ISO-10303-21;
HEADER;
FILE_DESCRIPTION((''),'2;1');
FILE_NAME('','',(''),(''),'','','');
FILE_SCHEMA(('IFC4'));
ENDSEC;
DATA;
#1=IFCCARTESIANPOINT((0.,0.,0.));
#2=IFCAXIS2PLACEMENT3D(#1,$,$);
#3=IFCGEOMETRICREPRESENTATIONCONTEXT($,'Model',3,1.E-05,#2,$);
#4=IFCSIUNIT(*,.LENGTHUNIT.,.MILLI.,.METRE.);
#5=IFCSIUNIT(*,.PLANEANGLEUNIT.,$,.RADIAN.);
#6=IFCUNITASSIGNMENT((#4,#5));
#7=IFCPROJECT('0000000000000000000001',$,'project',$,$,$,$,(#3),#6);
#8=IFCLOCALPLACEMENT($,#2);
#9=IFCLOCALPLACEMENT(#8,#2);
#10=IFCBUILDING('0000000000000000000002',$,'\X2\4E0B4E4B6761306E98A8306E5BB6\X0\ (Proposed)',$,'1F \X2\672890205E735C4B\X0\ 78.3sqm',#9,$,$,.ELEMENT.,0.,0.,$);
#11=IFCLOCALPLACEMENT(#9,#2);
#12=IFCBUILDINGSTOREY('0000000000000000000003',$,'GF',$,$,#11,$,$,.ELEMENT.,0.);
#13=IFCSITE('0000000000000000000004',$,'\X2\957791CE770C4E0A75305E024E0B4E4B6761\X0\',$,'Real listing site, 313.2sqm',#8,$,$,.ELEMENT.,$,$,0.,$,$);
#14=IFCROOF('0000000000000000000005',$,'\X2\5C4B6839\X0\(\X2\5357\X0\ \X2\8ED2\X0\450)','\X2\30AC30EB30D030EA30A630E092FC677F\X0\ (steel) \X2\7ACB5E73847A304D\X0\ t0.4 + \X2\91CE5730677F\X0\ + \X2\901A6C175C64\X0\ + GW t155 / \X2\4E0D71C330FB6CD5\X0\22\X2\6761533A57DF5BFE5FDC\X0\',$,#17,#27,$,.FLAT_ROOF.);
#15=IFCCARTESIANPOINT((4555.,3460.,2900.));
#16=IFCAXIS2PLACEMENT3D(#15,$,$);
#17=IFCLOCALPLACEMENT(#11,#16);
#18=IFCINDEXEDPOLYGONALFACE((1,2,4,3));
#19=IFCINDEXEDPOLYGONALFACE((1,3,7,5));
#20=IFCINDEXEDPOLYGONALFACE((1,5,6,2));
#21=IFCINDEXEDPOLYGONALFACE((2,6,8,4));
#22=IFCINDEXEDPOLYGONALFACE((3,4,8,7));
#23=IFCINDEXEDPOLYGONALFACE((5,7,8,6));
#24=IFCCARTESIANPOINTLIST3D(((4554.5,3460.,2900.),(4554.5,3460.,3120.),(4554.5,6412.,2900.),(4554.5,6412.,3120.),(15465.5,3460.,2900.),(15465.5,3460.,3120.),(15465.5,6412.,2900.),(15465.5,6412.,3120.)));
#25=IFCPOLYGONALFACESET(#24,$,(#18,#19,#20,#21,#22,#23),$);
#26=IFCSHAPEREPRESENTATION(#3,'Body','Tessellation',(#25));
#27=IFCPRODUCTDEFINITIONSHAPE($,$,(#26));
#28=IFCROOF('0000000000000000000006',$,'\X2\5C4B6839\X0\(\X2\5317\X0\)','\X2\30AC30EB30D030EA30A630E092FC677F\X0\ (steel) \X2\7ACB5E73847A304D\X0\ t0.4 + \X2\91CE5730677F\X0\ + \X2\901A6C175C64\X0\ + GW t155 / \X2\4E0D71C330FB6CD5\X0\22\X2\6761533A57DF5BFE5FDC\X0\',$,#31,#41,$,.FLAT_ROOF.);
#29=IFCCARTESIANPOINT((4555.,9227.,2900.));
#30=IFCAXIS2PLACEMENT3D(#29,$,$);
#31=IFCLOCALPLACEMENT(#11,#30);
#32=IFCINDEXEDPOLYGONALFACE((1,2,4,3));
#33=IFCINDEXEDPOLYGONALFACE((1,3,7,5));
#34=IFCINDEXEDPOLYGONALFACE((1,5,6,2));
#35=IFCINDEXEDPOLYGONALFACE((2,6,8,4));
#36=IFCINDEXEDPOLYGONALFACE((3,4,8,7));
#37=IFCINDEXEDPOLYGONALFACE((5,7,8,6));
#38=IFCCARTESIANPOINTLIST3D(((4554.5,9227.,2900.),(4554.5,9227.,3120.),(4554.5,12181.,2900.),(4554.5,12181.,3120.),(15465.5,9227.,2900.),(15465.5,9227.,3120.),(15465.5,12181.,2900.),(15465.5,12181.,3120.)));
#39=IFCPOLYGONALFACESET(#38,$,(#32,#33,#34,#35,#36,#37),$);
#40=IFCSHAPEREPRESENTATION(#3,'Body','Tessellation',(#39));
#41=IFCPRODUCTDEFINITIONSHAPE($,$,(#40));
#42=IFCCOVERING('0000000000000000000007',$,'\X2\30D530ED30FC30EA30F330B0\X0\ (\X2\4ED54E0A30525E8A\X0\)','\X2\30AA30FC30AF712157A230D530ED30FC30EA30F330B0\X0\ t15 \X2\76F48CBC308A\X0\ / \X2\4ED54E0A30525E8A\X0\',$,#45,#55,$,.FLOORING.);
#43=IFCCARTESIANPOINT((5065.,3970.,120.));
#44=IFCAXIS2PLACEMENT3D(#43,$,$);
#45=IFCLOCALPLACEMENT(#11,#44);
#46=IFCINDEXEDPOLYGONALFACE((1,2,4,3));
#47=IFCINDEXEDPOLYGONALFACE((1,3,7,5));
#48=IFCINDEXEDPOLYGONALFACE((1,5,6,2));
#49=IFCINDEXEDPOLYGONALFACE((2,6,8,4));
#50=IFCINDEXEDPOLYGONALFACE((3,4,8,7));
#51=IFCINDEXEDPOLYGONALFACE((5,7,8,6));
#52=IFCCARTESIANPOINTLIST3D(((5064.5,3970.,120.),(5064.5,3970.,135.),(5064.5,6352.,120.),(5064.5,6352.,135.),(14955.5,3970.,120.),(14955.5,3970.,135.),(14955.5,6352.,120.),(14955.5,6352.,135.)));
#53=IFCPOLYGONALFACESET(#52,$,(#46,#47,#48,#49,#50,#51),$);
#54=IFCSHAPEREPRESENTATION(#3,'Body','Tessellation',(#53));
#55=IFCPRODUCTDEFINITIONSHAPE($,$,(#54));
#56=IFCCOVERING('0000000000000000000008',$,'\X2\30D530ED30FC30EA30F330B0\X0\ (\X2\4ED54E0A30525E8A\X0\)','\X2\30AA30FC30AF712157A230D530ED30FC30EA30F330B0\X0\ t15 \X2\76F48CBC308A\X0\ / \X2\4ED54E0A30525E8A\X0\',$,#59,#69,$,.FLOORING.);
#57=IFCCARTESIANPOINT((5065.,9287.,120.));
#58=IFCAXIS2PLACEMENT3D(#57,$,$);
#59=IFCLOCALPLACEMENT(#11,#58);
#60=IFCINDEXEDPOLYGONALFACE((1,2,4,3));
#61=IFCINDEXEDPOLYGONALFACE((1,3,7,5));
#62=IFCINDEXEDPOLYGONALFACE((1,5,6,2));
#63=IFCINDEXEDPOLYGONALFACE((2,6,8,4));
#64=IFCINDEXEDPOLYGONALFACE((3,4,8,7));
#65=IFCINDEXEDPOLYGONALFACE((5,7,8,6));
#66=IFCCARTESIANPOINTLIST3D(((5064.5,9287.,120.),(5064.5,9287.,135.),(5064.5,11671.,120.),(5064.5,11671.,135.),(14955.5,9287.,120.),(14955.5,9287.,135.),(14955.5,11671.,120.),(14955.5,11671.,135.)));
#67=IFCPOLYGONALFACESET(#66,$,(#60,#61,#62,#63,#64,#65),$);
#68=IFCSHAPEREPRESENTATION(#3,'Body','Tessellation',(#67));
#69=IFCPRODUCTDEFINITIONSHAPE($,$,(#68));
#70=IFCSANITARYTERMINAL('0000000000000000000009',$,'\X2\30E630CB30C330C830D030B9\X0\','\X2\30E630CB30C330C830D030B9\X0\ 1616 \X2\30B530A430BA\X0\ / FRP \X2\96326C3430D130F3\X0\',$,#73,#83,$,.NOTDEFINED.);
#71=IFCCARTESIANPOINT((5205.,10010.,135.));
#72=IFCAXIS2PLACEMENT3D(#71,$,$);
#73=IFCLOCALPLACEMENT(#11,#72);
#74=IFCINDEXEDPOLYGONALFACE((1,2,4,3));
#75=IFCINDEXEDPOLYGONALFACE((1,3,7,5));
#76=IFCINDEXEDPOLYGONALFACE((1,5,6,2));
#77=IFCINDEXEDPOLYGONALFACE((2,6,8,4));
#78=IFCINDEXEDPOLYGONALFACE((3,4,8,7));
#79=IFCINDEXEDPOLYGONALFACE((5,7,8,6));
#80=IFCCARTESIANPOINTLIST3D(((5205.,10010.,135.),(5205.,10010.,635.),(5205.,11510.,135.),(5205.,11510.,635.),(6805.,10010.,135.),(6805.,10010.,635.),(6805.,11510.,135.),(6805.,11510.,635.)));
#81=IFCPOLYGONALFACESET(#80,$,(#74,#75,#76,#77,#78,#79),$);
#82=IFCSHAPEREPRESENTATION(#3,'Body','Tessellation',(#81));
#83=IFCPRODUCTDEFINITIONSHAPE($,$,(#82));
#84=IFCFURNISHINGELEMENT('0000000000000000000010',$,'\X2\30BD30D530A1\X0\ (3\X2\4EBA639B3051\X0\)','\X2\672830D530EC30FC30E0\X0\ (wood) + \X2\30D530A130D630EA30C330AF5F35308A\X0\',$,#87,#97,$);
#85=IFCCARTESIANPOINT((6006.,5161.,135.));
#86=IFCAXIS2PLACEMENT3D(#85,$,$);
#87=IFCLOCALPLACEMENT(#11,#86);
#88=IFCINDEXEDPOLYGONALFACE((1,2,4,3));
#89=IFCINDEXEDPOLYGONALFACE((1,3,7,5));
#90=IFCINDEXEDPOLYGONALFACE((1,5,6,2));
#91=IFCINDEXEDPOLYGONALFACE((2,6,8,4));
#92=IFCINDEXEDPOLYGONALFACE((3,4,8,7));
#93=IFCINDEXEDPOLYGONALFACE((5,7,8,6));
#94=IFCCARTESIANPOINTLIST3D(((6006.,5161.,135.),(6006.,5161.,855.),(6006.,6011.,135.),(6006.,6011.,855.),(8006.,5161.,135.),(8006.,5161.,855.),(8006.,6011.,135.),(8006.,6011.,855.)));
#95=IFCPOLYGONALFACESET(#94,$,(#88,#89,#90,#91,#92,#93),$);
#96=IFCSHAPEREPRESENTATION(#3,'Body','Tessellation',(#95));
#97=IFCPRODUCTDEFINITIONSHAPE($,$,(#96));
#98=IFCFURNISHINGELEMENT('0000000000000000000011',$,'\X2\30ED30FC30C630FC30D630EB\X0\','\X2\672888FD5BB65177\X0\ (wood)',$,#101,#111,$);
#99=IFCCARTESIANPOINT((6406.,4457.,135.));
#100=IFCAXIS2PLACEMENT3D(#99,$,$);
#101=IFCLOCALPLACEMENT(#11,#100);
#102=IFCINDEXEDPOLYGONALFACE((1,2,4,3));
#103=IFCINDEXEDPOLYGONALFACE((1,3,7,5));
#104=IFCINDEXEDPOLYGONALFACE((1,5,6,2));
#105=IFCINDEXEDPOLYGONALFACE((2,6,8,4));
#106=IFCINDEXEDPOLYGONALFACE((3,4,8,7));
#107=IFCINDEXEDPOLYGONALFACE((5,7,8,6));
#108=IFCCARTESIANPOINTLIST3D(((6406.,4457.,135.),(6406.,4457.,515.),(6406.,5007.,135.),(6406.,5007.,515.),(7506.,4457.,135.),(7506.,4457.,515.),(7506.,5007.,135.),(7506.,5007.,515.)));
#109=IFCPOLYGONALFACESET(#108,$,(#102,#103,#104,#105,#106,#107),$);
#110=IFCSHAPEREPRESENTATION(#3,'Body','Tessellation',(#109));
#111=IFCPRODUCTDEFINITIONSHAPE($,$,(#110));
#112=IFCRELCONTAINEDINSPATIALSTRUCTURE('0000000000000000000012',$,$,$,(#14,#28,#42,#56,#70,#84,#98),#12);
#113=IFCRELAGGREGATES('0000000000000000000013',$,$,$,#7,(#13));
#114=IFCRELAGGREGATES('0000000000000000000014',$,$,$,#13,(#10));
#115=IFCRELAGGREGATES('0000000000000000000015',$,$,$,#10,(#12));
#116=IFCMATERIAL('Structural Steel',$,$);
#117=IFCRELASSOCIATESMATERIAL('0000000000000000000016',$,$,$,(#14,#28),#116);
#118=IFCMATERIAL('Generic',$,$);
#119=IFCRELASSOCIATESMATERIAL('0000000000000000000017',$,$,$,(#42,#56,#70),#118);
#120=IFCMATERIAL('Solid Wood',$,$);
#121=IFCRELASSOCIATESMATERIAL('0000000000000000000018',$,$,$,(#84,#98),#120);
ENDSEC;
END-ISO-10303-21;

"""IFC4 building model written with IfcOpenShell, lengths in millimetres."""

from ifc_helpers import new_model, si_unit, frame, frame_2d, origin, place, context, project, spatial, rectangle, extrude, material, element, save


model = new_model("IFC4")

# Units and contexts
model_context = context("Model", 3, precision=1e-05, world=origin())
ifc_project = project(units=[si_unit("LENGTHUNIT", "METRE", prefix="MILLI"), si_unit("PLANEANGLEUNIT", "RADIAN")], contexts=[model_context])

# Site, building, storey
site_placement = place(None, origin())
site = spatial("IfcSite", under=ifc_project, at=site_placement, Name="長野県上田市下之条", ObjectType="Real listing site, 313.2sqm", CompositionType="ELEMENT", RefElevation=0.0)
building_placement = place(site_placement, origin())
building = spatial("IfcBuilding", under=site, at=building_placement, Name="下之条の風の家 (Proposed)", ObjectType="1F 木造平屋 78.3sqm", CompositionType="ELEMENT", ElevationOfRefHeight=0.0, ElevationOfTerrain=0.0)
storey_placement = place(building_placement, origin())
storey = spatial("IfcBuildingStorey", under=building, at=storey_placement, Name="GF", CompositionType="ELEMENT", Elevation=0.0)

# Shared definitions
ifc_material_1 = material(Name="Solid Wood")

# Roofs
ifc_material_2 = material(Name="Structural Steel")
roof_1_placement = place(storey_placement, frame((4555.0, 3460.0, 2900.0)))
element("IfcRoof", 1, at=roof_1_placement, inside=storey, material=ifc_material_2, Name="屋根(南 軒450)", Description="ガルバリウム鋼板 (steel) 立平葺き t0.4 + 野地板 + 通気層 + GW t155 / 不燃・法22条区域対応", PredefinedType="FLAT_ROOF", context=model_context, shape_type="SweptSolid", body=[
    extrude(rectangle(XDim=10911.0, YDim=2952.0, at=frame_2d((5455.0, 1476.0))), frame((4555.0, 3460.0, 2900.0)), (0.0, 0.0, 1.0), 220.0),
])
roof_2_placement = place(storey_placement, frame((4555.0, 9227.0, 2900.0)))
element("IfcRoof", 2, at=roof_2_placement, inside=storey, material=ifc_material_2, Name="屋根(北)", Description="ガルバリウム鋼板 (steel) 立平葺き t0.4 + 野地板 + 通気層 + GW t155 / 不燃・法22条区域対応", PredefinedType="FLAT_ROOF", context=model_context, shape_type="SweptSolid", body=[
    extrude(rectangle(XDim=10911.0, YDim=2954.0, at=frame_2d((5455.0, 1477.0))), frame((4555.0, 9227.0, 2900.0)), (0.0, 0.0, 1.0), 220.0),
])

# Coverings
ifc_material_3 = material(Name="Generic")
covering_1_placement = place(storey_placement, frame((5065.0, 3970.0, 120.0)))
element("IfcCovering", 3, at=covering_1_placement, inside=storey, material=ifc_material_3, Name="フローリング (仕上げ床)", Description="オーク無垢フローリング t15 直貼り / 仕上げ床", PredefinedType="FLOORING", context=model_context, shape_type="SweptSolid", body=[
    extrude(rectangle(XDim=9891.0, YDim=2382.0, at=frame_2d((4945.0, 1191.0))), frame((5065.0, 3970.0, 120.0)), (0.0, 0.0, 1.0), 15.0),
])
covering_2_placement = place(storey_placement, frame((5065.0, 9287.0, 120.0)))
element("IfcCovering", 4, at=covering_2_placement, inside=storey, material=ifc_material_3, Name="フローリング (仕上げ床)", Description="オーク無垢フローリング t15 直貼り / 仕上げ床", PredefinedType="FLOORING", context=model_context, shape_type="SweptSolid", body=[
    extrude(rectangle(XDim=9891.0, YDim=2384.0, at=frame_2d((4945.0, 1192.0))), frame((5065.0, 9287.0, 120.0)), (0.0, 0.0, 1.0), 15.0),
])

# Sanitary terminal
sanitary_terminal_placement = place(storey_placement, frame((5205.0, 10010.0, 135.0)))
element("IfcSanitaryTerminal", 5, at=sanitary_terminal_placement, inside=storey, material=ifc_material_3, Name="ユニットバス", Description="ユニットバス 1616 サイズ / FRP 防水パン", PredefinedType="NOTDEFINED", context=model_context, shape_type="SweptSolid", body=[
    extrude(rectangle(XDim=1600.0, YDim=1500.0, at=frame_2d((800.0, 750.0))), frame((5205.0, 10010.0, 135.0)), (0.0, 0.0, 1.0), 500.0),
])

# Furnishing elements
furnishing_1_placement = place(storey_placement, frame((6006.0, 5161.0, 135.0)))
element("IfcFurnishingElement", 6, at=furnishing_1_placement, inside=storey, material=ifc_material_1, Name="ソファ (3人掛け)", Description="木フレーム (wood) + ファブリック張り", context=model_context, shape_type="SweptSolid", body=[
    extrude(rectangle(XDim=2000.0, YDim=850.0, at=frame_2d((1000.0, 425.0))), frame((6006.0, 5161.0, 135.0)), (0.0, 0.0, 1.0), 720.0),
])
furnishing_2_placement = place(storey_placement, frame((6406.0, 4457.0, 135.0)))
element("IfcFurnishingElement", 7, at=furnishing_2_placement, inside=storey, material=ifc_material_1, Name="ローテーブル", Description="木製家具 (wood)", context=model_context, shape_type="SweptSolid", body=[
    extrude(rectangle(XDim=1100.0, YDim=550.0, at=frame_2d((550.0, 275.0))), frame((6406.0, 4457.0, 135.0)), (0.0, 0.0, 1.0), 380.0),
])

save(model, "model.ifc")
